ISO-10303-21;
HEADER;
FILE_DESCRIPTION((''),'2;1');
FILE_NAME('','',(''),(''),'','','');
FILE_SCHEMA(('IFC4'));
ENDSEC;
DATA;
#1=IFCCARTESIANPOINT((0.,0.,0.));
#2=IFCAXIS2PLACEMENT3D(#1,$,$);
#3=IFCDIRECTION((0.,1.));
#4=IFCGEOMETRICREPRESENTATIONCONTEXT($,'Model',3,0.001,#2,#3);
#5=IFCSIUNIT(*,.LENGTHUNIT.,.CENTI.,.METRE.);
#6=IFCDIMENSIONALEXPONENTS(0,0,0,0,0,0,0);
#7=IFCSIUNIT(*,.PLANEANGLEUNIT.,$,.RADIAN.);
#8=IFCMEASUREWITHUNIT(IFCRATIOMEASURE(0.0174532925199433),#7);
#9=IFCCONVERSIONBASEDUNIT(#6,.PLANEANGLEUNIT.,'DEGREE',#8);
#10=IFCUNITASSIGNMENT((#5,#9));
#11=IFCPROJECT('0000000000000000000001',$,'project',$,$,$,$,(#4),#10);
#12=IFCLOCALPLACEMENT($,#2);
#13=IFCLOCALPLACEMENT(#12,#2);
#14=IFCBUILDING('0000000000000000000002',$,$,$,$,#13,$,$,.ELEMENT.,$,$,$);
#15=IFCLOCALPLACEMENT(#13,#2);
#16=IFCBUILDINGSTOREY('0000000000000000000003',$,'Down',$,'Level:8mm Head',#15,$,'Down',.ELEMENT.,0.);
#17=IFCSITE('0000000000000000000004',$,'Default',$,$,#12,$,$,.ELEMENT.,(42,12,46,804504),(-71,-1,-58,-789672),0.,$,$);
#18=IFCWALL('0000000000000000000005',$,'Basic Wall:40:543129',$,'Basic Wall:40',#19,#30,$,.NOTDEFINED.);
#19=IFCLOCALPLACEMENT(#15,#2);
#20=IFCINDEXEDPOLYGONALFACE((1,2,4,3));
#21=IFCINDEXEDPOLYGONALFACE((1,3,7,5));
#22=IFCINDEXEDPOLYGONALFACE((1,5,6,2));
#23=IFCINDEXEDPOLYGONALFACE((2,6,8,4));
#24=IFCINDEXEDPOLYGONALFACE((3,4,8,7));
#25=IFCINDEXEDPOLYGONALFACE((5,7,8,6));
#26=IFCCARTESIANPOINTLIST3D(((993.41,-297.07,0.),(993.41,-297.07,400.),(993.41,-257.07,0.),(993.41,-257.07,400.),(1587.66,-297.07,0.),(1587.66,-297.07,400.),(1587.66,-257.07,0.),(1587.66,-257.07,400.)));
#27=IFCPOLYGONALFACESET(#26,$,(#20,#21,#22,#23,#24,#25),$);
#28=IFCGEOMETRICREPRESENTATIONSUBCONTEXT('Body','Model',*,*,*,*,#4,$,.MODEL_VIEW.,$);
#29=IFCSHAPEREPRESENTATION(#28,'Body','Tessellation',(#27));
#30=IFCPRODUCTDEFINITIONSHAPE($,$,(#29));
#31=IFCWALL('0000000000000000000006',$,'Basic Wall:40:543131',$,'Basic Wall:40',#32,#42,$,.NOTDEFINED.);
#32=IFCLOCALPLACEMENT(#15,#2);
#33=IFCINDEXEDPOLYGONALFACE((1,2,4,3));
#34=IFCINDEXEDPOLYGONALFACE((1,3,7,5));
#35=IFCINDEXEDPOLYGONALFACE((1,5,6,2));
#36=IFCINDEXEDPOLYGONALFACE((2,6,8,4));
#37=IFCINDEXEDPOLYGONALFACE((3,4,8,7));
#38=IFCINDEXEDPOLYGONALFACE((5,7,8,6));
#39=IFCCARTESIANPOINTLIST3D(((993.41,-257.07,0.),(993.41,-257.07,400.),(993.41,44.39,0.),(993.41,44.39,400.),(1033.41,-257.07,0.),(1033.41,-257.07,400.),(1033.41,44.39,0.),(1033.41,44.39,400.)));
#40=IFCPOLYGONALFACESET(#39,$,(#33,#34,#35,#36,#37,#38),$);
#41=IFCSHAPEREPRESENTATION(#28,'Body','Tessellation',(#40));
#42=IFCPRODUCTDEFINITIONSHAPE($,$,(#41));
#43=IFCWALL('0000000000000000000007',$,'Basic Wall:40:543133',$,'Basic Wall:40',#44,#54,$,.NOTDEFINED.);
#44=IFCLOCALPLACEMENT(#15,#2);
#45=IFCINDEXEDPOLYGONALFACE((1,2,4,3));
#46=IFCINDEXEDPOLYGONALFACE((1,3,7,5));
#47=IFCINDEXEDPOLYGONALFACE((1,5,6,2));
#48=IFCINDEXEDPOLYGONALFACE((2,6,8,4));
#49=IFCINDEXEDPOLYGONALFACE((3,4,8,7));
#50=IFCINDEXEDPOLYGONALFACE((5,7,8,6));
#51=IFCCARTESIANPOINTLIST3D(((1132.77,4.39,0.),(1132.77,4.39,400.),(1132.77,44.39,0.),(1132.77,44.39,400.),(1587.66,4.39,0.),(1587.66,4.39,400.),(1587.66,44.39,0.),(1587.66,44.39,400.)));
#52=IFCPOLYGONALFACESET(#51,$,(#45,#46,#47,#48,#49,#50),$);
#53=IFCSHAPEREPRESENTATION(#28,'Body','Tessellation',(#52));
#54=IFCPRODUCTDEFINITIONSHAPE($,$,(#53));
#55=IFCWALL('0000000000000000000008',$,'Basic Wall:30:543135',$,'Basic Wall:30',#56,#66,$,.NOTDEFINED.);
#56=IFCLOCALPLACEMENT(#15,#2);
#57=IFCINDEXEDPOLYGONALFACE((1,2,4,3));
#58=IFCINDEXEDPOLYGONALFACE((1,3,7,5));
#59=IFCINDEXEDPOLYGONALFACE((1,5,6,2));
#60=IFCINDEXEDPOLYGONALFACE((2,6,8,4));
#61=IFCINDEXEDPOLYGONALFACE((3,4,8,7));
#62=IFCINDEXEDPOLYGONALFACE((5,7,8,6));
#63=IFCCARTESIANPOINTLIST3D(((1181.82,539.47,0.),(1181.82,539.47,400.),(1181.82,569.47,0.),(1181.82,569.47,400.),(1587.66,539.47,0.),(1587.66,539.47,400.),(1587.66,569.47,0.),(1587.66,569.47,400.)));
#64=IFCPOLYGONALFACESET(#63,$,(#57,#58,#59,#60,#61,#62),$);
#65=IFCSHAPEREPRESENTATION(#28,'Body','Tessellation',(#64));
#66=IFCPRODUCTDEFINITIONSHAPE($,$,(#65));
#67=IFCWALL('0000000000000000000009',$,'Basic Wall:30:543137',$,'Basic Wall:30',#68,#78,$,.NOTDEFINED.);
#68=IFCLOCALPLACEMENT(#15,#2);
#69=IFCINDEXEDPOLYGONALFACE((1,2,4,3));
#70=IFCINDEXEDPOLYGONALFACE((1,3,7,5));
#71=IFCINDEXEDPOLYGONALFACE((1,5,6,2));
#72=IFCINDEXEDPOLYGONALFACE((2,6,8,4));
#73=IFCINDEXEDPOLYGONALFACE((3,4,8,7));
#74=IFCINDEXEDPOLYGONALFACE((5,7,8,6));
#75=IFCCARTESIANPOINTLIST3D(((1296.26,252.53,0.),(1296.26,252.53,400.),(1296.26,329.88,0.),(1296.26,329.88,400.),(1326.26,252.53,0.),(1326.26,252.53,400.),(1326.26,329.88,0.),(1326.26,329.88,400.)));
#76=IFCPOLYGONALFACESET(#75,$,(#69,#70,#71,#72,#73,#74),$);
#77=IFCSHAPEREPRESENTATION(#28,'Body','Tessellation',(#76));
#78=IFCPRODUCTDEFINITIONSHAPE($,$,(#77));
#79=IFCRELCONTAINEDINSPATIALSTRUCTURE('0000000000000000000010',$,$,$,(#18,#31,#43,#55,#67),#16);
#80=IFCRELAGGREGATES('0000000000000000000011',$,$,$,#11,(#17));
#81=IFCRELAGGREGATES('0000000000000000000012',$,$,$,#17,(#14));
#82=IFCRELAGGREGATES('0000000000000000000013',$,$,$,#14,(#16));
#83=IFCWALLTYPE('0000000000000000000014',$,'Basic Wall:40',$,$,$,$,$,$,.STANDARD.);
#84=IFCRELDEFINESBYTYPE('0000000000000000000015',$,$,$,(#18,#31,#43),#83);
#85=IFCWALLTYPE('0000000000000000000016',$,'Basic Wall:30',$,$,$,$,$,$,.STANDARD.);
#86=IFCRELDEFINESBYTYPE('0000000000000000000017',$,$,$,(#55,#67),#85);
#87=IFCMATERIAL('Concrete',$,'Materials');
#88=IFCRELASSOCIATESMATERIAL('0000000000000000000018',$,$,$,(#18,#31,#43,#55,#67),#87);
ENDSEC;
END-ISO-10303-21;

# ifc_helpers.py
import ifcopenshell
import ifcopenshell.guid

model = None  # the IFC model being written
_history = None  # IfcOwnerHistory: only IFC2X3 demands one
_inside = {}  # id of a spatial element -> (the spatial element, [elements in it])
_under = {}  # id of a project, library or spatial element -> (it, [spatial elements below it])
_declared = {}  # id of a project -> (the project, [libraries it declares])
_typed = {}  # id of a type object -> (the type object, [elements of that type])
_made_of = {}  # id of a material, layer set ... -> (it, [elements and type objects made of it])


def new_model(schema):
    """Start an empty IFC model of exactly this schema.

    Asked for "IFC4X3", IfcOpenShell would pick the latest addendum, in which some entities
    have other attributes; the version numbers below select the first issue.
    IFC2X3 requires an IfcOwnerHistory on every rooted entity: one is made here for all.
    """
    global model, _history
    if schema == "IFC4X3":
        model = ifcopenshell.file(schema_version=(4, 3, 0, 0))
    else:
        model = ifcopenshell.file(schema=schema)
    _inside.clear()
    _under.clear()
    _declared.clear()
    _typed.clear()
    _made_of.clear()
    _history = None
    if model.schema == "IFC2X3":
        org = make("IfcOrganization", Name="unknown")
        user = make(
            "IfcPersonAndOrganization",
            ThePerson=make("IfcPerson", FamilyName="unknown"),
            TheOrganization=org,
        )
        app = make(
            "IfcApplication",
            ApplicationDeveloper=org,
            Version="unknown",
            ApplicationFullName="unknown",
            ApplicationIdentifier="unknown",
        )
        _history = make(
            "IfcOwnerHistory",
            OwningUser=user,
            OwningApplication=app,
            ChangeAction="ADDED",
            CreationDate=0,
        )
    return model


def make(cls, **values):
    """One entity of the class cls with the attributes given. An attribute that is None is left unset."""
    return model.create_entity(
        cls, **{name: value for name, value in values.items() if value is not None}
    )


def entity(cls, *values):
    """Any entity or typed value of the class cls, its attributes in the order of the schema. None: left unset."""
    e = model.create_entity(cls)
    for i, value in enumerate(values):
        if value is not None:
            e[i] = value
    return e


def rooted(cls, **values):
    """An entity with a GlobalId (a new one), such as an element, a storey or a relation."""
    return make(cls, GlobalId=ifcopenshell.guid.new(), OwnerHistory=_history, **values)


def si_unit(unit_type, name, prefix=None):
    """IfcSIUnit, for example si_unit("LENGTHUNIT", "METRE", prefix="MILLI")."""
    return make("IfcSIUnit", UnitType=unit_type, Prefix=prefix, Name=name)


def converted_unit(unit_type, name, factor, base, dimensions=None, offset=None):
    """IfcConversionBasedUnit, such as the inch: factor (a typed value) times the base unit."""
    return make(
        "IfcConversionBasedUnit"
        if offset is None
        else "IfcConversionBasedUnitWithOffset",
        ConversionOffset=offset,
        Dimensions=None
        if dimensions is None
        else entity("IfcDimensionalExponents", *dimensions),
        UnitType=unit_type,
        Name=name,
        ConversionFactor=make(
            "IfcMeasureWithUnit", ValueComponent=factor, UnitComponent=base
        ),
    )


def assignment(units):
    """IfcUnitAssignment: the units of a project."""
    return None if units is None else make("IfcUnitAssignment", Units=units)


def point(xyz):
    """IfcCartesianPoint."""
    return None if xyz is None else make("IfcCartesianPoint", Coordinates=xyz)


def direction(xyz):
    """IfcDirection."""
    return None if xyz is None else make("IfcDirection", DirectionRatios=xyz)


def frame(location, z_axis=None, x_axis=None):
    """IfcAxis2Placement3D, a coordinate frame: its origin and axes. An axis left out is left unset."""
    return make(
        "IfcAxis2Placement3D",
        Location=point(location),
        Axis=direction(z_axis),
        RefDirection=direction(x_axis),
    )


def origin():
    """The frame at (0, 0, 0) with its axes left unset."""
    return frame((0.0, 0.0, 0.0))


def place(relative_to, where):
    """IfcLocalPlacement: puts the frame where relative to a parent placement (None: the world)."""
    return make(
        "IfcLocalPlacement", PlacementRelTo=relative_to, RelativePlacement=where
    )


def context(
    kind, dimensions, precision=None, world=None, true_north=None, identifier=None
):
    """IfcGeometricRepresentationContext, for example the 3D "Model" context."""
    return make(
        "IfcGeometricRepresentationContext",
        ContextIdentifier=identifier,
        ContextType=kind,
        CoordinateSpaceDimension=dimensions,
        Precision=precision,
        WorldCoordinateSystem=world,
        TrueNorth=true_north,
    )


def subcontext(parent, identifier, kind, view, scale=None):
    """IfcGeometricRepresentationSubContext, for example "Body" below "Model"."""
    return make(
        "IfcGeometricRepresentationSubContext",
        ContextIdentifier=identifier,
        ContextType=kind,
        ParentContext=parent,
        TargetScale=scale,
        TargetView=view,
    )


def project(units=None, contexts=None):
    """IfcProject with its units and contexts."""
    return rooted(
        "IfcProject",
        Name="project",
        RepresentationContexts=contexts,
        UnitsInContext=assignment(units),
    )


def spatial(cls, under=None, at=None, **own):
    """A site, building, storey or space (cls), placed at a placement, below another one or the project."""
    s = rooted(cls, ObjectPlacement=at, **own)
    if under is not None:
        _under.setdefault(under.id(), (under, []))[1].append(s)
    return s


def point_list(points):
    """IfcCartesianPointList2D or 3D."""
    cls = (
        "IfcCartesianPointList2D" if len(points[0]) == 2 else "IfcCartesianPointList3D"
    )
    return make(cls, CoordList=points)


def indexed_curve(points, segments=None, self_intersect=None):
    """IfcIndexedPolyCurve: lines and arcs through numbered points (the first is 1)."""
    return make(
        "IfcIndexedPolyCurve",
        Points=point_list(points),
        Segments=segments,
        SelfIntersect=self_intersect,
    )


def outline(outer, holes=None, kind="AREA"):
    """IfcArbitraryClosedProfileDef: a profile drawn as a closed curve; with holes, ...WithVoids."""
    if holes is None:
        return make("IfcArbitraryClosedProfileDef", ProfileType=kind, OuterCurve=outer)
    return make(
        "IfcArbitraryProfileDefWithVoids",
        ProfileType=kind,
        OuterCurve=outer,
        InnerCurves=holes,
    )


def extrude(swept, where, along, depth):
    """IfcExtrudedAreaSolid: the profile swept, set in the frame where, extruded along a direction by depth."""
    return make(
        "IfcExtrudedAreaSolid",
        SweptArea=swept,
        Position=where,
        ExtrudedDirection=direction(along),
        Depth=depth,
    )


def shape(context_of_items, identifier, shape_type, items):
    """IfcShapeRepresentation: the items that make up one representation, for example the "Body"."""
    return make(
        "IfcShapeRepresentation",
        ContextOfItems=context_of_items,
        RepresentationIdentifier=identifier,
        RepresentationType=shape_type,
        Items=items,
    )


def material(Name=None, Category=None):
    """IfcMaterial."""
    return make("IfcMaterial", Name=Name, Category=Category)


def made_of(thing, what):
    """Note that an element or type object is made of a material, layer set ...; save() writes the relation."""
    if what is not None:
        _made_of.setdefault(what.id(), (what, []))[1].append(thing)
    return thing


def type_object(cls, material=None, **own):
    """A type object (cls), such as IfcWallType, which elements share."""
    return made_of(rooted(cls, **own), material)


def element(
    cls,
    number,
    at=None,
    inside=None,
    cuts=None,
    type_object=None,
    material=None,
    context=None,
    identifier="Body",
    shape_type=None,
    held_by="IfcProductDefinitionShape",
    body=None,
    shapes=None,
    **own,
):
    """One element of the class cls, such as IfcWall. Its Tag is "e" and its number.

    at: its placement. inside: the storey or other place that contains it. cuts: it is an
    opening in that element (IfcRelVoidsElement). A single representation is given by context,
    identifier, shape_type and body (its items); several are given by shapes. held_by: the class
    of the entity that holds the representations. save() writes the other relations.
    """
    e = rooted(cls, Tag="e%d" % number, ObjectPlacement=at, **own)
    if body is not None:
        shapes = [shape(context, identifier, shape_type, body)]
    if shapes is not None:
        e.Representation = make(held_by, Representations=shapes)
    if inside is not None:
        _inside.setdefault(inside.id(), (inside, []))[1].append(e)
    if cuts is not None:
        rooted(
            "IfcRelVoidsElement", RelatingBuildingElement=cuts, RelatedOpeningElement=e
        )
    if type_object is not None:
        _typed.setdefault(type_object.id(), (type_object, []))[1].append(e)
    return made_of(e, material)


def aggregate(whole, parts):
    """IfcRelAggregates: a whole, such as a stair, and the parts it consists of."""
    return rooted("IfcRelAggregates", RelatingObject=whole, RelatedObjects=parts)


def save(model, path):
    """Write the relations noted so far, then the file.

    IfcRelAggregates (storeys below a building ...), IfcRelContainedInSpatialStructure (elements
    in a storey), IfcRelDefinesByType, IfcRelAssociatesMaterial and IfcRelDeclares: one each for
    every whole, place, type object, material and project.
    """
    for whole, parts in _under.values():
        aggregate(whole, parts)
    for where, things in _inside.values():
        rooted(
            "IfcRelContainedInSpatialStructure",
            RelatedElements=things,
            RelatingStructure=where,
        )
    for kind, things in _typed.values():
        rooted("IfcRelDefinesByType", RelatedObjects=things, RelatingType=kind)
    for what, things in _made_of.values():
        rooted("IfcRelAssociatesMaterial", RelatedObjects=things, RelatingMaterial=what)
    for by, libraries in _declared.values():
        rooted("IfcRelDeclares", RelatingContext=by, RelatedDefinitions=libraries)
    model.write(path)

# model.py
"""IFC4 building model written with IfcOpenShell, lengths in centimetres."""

from ifc_helpers import new_model, entity, si_unit, converted_unit, direction, frame, origin, place, context, subcontext, project, spatial, indexed_curve, outline, extrude, material, type_object, element, save


model = new_model("IFC4")

# Units and contexts
model_context = context("Model", 3, precision=0.001, world=origin(), true_north=direction((0.0, 1.0)))
body_context = subcontext(model_context, "Body", "Model", "MODEL_VIEW")
ifc_project = project(units=[si_unit("LENGTHUNIT", "METRE", prefix="CENTI"), converted_unit("PLANEANGLEUNIT", "DEGREE", entity("IfcRatioMeasure", 0.0174532925199433), si_unit("PLANEANGLEUNIT", "RADIAN"), dimensions=[0, 0, 0, 0, 0, 0, 0])], contexts=[model_context])

# Site, building, storey
site_placement = place(None, origin())
site = spatial("IfcSite", under=ifc_project, at=site_placement, Name="Default", CompositionType="ELEMENT", RefLatitude=(42, 12, 46, 804504), RefLongitude=(-71, -1, -58, -789672), RefElevation=0.0)
building_placement = place(site_placement, origin())
building = spatial("IfcBuilding", under=site, at=building_placement, CompositionType="ELEMENT")
storey_placement = place(building_placement, origin())
storey = spatial("IfcBuildingStorey", under=building, at=storey_placement, Name="Down", ObjectType="Level:8mm Head", LongName="Down", CompositionType="ELEMENT", Elevation=0.0)

# Shared definitions
ifc_material = material(Name="Concrete", Category="Materials")

# Walls
wall_type_1 = type_object("IfcWallType", Name="Basic Wall:40", PredefinedType="STANDARD")
wall_1_placement = place(storey_placement, frame((1587.66, -277.07, 0.0), z_axis=(0.0, 0.0, 1.0), x_axis=(-1.0, 0.0, 0.0)))
element("IfcWall", 1, at=wall_1_placement, inside=storey, type_object=wall_type_1, material=ifc_material, Name="Basic Wall:40:543129", ObjectType="Basic Wall:40", PredefinedType="NOTDEFINED", context=body_context, shape_type="SweptSolid", body=[
    extrude(outline(indexed_curve([(594.25, 20.0), (0.0, 20.0), (0.0, -20.0), (594.25, -20.0), (594.25, 20.0)], self_intersect=False)), origin(), (0.0, 0.0, 1.0), 400.0),
])
wall_2_placement = place(storey_placement, frame((1013.41, -257.07, 0.0), z_axis=(0.0, 0.0, 1.0), x_axis=(0.0, 1.0, 0.0)))
element("IfcWall", 2, at=wall_2_placement, inside=storey, type_object=wall_type_1, material=ifc_material, Name="Basic Wall:40:543131", ObjectType="Basic Wall:40", PredefinedType="NOTDEFINED", context=body_context, shape_type="SweptSolid", body=[
    extrude(outline(indexed_curve([(301.46, 20.0), (0.0, 20.0), (0.0, -20.0), (301.46, -20.0), (301.46, 20.0)], self_intersect=False)), origin(), (0.0, 0.0, 1.0), 400.0),
])
wall_3_placement = place(storey_placement, frame((1132.77, 24.39, 0.0)))
element("IfcWall", 3, at=wall_3_placement, inside=storey, type_object=wall_type_1, material=ifc_material, Name="Basic Wall:40:543133", ObjectType="Basic Wall:40", PredefinedType="NOTDEFINED", context=body_context, shape_type="SweptSolid", body=[
    extrude(outline(indexed_curve([(454.89, 20.0), (0.0, 20.0), (0.0, -20.0), (454.89, -20.0), (454.89, 20.0)], self_intersect=False)), origin(), (0.0, 0.0, 1.0), 400.0),
])
wall_type_2 = type_object("IfcWallType", Name="Basic Wall:30", PredefinedType="STANDARD")
wall_4_placement = place(storey_placement, frame((1587.66, 554.47, 0.0), z_axis=(0.0, 0.0, 1.0), x_axis=(-1.0, 0.0, 0.0)))
element("IfcWall", 4, at=wall_4_placement, inside=storey, type_object=wall_type_2, material=ifc_material, Name="Basic Wall:30:543135", ObjectType="Basic Wall:30", PredefinedType="NOTDEFINED", context=body_context, shape_type="SweptSolid", body=[
    extrude(outline(indexed_curve([(405.84, 15.0), (0.0, 15.0), (0.0, -15.0), (405.84, -15.0), (405.84, 15.0)], self_intersect=False)), origin(), (0.0, 0.0, 1.0), 400.0),
])
wall_5_placement = place(storey_placement, frame((1311.26, 329.88, 0.0), z_axis=(0.0, 0.0, 1.0), x_axis=(0.0, -1.0, 0.0)))
element("IfcWall", 5, at=wall_5_placement, inside=storey, type_object=wall_type_2, material=ifc_material, Name="Basic Wall:30:543137", ObjectType="Basic Wall:30", PredefinedType="NOTDEFINED", context=body_context, shape_type="SweptSolid", body=[
    extrude(outline(indexed_curve([(77.35, 15.0), (0.0, 15.0), (0.0, -15.0), (77.35, -15.0), (77.35, 15.0)], self_intersect=False)), origin(), (0.0, 0.0, 1.0), 400.0),
])

save(model, "model.ifc")
